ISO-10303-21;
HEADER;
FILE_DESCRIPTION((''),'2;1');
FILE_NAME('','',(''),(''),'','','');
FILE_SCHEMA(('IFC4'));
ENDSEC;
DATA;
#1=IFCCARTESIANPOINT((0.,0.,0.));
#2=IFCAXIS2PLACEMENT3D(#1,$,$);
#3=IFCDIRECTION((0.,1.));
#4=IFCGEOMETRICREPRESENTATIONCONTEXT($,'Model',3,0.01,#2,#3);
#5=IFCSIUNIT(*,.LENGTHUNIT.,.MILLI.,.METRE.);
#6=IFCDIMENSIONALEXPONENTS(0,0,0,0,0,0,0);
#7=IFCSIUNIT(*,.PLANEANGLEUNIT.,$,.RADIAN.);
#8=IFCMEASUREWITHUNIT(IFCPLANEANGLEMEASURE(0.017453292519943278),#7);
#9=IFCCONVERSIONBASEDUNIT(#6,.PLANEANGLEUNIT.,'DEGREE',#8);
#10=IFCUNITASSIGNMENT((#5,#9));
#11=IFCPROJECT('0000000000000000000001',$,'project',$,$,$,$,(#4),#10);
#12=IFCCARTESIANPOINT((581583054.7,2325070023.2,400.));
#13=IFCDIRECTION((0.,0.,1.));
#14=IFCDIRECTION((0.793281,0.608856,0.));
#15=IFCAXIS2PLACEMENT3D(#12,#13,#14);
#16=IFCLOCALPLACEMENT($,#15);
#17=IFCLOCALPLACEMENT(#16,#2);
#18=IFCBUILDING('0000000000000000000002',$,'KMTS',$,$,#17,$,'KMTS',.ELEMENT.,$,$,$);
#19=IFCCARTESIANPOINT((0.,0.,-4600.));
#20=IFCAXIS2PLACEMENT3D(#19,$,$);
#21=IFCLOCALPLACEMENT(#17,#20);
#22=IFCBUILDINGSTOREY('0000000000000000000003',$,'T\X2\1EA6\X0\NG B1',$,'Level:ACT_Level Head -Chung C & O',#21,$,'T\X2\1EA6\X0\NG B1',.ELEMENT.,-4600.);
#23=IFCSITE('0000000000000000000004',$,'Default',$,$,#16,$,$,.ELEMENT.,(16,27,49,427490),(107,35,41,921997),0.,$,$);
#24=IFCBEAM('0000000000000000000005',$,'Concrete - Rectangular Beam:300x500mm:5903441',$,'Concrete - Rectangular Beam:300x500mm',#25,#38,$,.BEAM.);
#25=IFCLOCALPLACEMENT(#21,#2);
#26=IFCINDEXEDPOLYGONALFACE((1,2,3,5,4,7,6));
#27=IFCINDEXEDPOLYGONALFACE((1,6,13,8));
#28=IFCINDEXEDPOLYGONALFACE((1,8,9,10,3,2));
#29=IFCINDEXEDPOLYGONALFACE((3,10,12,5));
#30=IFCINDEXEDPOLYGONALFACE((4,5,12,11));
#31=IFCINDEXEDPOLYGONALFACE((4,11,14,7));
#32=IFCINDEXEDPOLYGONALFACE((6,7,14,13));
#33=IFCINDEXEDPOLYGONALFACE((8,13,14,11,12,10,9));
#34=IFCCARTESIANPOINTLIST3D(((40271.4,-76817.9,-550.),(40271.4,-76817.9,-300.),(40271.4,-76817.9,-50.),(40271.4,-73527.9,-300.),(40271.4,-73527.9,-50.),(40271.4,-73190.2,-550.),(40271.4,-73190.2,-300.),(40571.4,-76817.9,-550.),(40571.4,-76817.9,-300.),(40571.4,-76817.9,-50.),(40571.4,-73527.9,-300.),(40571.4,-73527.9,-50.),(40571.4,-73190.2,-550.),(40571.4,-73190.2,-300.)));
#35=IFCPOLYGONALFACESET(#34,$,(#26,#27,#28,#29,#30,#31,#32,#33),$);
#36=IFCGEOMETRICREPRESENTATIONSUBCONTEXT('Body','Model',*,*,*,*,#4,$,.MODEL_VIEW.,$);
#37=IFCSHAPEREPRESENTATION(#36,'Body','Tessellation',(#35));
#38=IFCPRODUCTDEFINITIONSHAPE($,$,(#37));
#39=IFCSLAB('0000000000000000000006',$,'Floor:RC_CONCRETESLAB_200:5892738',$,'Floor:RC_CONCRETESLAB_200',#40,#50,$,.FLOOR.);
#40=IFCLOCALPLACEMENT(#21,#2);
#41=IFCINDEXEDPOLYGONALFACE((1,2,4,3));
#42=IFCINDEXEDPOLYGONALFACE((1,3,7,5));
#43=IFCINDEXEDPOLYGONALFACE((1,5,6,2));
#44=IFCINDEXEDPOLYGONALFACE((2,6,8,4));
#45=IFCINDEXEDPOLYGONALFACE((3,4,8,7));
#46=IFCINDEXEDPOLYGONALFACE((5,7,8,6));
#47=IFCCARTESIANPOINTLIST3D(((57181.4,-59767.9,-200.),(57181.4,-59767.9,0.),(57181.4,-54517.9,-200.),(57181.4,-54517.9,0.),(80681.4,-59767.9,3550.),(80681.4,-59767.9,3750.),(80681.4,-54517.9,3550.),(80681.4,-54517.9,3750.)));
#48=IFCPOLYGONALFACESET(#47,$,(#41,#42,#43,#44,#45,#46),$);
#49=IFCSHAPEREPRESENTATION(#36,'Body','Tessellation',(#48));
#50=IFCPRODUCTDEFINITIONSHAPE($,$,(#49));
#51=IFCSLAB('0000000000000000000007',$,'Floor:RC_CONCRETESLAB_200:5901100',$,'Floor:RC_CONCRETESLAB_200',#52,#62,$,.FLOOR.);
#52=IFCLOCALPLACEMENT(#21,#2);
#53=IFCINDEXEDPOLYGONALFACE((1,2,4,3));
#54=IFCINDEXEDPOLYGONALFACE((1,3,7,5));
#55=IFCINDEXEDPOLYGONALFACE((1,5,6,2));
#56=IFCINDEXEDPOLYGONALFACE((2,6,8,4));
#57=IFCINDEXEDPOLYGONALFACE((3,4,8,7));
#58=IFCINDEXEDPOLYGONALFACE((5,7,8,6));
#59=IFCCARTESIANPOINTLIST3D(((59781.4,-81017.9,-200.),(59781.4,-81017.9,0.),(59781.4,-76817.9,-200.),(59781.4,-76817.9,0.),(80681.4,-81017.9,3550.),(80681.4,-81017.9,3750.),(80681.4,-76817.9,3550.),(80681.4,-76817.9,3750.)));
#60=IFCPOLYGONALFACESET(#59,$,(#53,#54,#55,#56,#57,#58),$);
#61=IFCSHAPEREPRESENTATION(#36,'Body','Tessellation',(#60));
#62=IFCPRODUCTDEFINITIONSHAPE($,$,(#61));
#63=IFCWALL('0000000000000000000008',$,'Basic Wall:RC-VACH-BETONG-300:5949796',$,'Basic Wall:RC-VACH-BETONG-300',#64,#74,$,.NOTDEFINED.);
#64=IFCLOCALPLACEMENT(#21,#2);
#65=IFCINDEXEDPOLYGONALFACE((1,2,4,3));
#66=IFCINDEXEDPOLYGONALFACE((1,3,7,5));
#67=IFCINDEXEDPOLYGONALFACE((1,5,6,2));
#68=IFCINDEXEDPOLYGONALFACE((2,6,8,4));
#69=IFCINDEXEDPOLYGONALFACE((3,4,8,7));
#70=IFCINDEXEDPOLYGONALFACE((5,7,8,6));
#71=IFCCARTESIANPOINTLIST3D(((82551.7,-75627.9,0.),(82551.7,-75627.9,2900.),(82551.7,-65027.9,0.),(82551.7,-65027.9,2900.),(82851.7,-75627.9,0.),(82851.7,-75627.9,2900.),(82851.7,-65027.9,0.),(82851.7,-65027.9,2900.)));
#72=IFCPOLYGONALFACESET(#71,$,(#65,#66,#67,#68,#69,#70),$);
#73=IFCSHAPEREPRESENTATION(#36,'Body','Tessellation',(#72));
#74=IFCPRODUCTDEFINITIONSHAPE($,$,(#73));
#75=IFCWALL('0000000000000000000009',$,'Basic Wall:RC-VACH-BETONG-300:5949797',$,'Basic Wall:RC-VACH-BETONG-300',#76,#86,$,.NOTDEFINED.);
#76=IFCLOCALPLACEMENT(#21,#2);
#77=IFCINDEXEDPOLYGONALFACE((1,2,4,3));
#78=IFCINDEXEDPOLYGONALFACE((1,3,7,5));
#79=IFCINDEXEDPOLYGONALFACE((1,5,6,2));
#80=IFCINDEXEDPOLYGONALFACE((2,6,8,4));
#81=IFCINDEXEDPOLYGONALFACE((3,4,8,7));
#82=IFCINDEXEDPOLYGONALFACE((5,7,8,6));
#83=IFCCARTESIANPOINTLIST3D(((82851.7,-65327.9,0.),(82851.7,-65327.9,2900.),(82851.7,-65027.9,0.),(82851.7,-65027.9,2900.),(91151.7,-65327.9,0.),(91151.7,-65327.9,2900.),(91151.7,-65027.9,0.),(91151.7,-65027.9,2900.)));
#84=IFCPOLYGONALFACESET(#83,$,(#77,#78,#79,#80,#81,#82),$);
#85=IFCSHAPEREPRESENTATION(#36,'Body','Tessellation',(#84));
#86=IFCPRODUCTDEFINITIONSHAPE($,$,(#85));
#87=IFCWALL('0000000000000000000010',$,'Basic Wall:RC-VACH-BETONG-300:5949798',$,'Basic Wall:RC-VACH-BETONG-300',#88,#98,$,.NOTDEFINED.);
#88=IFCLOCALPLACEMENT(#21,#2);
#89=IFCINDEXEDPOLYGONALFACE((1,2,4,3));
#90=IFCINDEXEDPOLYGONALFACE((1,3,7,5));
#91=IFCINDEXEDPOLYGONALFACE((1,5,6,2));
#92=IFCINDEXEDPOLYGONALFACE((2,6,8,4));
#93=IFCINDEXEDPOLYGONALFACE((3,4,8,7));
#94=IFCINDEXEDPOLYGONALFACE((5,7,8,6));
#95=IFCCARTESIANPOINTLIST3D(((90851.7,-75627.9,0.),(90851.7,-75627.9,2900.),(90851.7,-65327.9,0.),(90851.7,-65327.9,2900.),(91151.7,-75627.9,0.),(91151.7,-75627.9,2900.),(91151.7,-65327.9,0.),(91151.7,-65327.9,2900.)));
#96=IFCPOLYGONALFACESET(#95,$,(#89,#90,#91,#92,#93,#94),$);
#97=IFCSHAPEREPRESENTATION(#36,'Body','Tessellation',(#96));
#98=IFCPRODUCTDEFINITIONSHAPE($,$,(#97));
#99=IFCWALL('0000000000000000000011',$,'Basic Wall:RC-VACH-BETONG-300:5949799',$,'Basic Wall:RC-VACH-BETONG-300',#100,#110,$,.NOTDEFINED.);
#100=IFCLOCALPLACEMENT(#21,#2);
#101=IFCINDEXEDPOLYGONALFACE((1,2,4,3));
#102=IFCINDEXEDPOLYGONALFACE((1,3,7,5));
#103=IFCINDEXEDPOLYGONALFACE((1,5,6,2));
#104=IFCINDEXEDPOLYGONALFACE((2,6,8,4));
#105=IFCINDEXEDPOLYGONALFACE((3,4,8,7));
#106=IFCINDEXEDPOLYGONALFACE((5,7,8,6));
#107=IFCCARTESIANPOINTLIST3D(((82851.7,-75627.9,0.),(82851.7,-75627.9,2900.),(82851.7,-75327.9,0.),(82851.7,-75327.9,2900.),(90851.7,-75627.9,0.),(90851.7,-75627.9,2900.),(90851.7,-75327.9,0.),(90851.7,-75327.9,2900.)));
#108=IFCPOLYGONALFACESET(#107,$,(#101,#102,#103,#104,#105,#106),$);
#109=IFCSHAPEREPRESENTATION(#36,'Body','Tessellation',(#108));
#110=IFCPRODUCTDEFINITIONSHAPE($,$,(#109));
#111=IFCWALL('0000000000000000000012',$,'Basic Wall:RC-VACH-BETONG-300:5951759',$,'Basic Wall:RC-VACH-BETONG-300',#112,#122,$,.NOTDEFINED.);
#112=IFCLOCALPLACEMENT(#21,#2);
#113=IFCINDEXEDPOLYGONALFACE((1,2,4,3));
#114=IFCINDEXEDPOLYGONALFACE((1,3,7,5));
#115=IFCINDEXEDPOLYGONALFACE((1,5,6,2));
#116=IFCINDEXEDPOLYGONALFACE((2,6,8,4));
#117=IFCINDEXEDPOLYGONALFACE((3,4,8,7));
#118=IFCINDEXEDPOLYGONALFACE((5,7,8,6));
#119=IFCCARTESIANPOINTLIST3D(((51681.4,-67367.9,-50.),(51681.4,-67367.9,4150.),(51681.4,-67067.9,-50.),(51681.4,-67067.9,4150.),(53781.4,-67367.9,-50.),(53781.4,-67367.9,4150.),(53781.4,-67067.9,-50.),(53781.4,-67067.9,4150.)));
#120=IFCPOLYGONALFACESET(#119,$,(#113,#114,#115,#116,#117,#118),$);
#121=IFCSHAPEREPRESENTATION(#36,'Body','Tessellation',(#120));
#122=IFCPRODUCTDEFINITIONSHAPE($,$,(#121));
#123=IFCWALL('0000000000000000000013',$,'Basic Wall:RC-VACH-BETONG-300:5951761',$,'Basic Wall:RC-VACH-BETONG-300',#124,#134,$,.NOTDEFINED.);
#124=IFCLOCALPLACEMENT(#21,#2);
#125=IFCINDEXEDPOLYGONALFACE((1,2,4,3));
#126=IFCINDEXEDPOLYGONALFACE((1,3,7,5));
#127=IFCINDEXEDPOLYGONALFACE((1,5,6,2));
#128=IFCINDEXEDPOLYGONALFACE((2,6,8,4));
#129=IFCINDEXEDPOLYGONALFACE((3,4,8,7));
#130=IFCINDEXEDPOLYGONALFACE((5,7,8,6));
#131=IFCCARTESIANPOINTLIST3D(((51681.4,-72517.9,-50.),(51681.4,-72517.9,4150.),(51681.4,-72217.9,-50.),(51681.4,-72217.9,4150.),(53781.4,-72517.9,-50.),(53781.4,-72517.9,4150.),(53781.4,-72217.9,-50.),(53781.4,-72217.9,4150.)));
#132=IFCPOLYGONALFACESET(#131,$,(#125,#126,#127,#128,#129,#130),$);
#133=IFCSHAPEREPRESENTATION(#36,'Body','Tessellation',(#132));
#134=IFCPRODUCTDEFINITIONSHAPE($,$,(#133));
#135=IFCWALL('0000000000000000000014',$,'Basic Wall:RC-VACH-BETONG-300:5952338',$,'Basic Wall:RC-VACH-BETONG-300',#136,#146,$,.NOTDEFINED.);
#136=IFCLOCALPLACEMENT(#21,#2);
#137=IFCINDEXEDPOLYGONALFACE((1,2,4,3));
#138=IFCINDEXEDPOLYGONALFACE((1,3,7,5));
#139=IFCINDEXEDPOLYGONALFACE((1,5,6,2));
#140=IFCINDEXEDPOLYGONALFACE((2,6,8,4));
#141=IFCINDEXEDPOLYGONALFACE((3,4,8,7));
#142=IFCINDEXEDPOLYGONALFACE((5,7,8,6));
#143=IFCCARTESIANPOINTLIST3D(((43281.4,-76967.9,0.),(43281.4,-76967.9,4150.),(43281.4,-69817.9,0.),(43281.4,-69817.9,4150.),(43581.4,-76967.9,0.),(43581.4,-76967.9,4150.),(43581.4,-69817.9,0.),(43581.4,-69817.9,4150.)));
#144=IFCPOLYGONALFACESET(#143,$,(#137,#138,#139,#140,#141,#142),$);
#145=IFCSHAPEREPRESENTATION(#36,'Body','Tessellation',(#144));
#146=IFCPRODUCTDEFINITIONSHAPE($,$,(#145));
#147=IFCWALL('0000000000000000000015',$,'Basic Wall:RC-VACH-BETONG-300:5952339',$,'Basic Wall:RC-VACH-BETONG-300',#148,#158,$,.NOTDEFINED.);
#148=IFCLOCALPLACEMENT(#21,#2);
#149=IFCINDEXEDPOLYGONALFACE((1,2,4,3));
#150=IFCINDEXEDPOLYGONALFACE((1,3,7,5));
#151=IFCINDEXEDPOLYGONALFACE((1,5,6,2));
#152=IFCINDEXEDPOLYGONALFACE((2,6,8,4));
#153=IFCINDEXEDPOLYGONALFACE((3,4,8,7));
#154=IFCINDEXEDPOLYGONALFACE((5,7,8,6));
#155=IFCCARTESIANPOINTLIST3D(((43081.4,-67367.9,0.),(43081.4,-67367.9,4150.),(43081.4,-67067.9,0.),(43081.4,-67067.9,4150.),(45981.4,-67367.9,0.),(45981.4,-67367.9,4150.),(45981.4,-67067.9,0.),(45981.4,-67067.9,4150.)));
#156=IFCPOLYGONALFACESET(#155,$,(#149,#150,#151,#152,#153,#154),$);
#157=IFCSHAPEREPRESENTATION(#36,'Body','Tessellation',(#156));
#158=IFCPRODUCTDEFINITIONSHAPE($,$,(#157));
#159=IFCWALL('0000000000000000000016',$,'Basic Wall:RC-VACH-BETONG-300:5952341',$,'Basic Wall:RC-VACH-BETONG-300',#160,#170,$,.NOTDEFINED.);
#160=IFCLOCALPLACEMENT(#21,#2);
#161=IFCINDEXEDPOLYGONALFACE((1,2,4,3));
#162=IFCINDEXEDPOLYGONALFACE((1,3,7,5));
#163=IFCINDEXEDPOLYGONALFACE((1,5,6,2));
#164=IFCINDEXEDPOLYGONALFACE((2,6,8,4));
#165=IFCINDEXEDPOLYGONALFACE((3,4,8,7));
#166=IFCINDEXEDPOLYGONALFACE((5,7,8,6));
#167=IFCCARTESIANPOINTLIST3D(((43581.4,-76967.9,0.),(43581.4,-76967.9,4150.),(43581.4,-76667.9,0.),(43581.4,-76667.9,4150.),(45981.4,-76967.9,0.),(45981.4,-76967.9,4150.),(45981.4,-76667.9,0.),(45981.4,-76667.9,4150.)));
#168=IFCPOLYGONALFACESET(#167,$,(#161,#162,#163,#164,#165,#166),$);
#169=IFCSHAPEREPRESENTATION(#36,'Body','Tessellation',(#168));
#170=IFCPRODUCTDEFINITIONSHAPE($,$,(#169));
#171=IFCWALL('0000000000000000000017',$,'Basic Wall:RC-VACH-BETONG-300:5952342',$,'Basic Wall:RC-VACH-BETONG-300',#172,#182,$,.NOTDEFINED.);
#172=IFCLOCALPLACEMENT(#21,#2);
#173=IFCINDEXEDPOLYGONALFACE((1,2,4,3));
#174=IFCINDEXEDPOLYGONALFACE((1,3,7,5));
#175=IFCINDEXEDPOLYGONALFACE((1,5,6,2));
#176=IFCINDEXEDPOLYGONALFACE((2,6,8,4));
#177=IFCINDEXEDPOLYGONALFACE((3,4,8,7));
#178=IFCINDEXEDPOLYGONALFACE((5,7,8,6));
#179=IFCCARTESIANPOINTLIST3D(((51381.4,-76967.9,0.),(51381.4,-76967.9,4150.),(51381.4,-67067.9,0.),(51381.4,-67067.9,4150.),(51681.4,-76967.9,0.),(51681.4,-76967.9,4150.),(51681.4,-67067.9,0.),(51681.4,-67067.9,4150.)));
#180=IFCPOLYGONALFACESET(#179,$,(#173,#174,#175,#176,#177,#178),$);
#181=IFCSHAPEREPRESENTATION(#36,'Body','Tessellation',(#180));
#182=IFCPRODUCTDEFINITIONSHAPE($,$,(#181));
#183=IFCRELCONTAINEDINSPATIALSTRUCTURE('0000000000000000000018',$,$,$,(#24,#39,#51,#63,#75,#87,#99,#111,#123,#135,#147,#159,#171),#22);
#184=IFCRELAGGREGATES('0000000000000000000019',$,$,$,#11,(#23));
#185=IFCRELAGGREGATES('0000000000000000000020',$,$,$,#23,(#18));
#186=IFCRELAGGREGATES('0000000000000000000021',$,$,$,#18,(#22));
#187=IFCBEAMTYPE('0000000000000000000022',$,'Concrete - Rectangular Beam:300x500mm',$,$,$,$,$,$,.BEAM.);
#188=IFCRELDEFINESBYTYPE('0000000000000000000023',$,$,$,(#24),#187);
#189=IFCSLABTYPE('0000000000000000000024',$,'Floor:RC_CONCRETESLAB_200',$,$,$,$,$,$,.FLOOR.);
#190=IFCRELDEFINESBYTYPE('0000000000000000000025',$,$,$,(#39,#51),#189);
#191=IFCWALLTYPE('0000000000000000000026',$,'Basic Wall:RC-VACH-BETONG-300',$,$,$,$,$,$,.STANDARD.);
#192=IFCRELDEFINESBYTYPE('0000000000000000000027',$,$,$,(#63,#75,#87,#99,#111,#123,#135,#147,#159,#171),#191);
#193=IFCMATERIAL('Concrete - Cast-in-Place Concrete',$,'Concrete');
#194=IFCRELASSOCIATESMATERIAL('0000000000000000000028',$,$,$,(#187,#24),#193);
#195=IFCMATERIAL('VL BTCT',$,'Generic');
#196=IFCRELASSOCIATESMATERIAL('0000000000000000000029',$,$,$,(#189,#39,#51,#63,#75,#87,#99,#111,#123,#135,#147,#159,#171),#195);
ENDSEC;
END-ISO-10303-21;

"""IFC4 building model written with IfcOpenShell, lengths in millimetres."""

from ifc_helpers import new_model, entity, si_unit, converted_unit, direction, frame, frame_2d, origin, place, context, subcontext, project, spatial, indexed_curve, rectangle, outline, extrude, source, transform, mapped, material, type_object, type_shapes, element, save


model = new_model("IFC4")

# Units and contexts
model_context = context("Model", 3, precision=0.01, world=origin(), true_north=direction((0.0, 1.0)))
body_context = subcontext(model_context, "Body", "Model", "MODEL_VIEW")
ifc_project = project(units=[si_unit("LENGTHUNIT", "METRE", prefix="MILLI"), converted_unit("PLANEANGLEUNIT", "DEGREE", entity("IfcPlaneAngleMeasure", 0.017453292519943278), si_unit("PLANEANGLEUNIT", "RADIAN"), dimensions=[0, 0, 0, 0, 0, 0, 0])], contexts=[model_context])

# Site, building, storey
site_placement = place(None, frame((581583054.7, 2325070023.2, 400.0), z_axis=(0.0, 0.0, 1.0), x_axis=(0.793281, 0.608856, 0.0)))
site = spatial("IfcSite", under=ifc_project, at=site_placement, Name="Default", CompositionType="ELEMENT", RefLatitude=(16, 27, 49, 427490), RefLongitude=(107, 35, 41, 921997), RefElevation=0.0)
building_placement = place(site_placement, origin())
building = spatial("IfcBuilding", under=site, at=building_placement, Name="KMTS", LongName="KMTS", CompositionType="ELEMENT")
storey_placement = place(building_placement, frame((0.0, 0.0, -4600.0)))
storey = spatial("IfcBuildingStorey", under=building, at=storey_placement, Name="TẦNG B1", ObjectType="Level:ACT_Level Head -Chung C & O", LongName="TẦNG B1", CompositionType="ELEMENT", Elevation=-4600.0)

# Beam
ifc_material_1 = material(Name="VL BTCT", Category="Generic")
ifc_material_2 = material(Name="Concrete - Cast-in-Place Concrete", Category="Concrete")
beam_type_1 = type_object("IfcBeamType", Name="Concrete - Rectangular Beam:300x500mm", PredefinedType="BEAM", material=ifc_material_2)
shared_shape_1 = source(origin(), body_context, "Body", "SweptSolid", [
    extrude(outline(indexed_curve([(-250.0, -1651.2), (0.0, -1651.2), (0.0, -1313.5), (250.0, -1313.5), (250.0, 1976.5), (0.0, 1976.5), (-250.0, 1976.5), (-250.0, -1651.2)], self_intersect=False)), frame((0.0, 1976.5, 250.0), z_axis=(1.0, 0.0, 0.0), x_axis=(0.0, 0.0, 1.0)), (0.0, 0.0, 1.0), 300.0),
])
type_shapes(beam_type_1, [shared_shape_1])
beam_1_placement = place(storey_placement, frame((40271.4, -76817.9, -550.0)))
element("IfcBeam", 1, at=beam_1_placement, inside=storey, type_object=beam_type_1, material=ifc_material_2, Name="Concrete - Rectangular Beam:300x500mm:5903441", ObjectType="Concrete - Rectangular Beam:300x500mm", PredefinedType="BEAM", context=body_context, shape_type="MappedRepresentation", body=[
    mapped(shared_shape_1, transform((0.0, 0.0, 0.0), scale=1.0)),
])

# Slabs
slab_type = type_object("IfcSlabType", Name="Floor:RC_CONCRETESLAB_200", PredefinedType="FLOOR", material=ifc_material_1)
slab_1_placement = place(storey_placement, frame((57181.4, -59767.9, -200.0)))
element("IfcSlab", 2, at=slab_1_placement, inside=storey, type_object=slab_type, material=ifc_material_1, Name="Floor:RC_CONCRETESLAB_200:5892738", ObjectType="Floor:RC_CONCRETESLAB_200", PredefinedType="FLOOR", context=body_context, shape_type="SweptSolid", body=[
    extrude(rectangle(XDim=5250.0, YDim=23797.3, at=frame_2d((0.0, 0.0), x_axis=(0.0, 1.0))), frame((11750.0, 2625.0, 2075.0), z_axis=(-0.157581, 0.0, 0.987506), x_axis=(0.987506, 0.0, 0.157581)), (-0.157581, 0.0, -0.987506), 200.0),
])
slab_2_placement = place(storey_placement, frame((59781.4, -81017.9, -200.0)))
element("IfcSlab", 3, at=slab_2_placement, inside=storey, type_object=slab_type, material=ifc_material_1, Name="Floor:RC_CONCRETESLAB_200:5901100", ObjectType="Floor:RC_CONCRETESLAB_200", PredefinedType="FLOOR", context=body_context, shape_type="SweptSolid", body=[
    extrude(rectangle(XDim=21233.8, YDim=4200.0, at=frame_2d((0.0, 0.0), x_axis=(-1.0, 0.0))), frame((10450.0, 2100.0, 2075.0), z_axis=(-0.176606, 0.0, 0.984282), x_axis=(0.984282, 0.0, 0.176606)), (-0.176606, 0.0, -0.984282), 200.0),
])

# Walls
wall_type_1 = type_object("IfcWallType", Name="Basic Wall:RC-VACH-BETONG-300", PredefinedType="STANDARD")
wall_1_placement = place(storey_placement, frame((82701.7, -75627.9, 0.0), z_axis=(0.0, 0.0, 1.0), x_axis=(0.0, 1.0, 0.0)))
element("IfcWall", 4, at=wall_1_placement, inside=storey, type_object=wall_type_1, material=ifc_material_1, Name="Basic Wall:RC-VACH-BETONG-300:5949796", ObjectType="Basic Wall:RC-VACH-BETONG-300", PredefinedType="NOTDEFINED", context=body_context, shape_type="SweptSolid", body=[
    extrude(outline(indexed_curve([(10600.0, 150.0), (0.0, 150.0), (0.0, -150.0), (10600.0, -150.0), (10600.0, 150.0)], self_intersect=False)), origin(), (0.0, 0.0, 1.0), 2900.0),
])
wall_2_placement = place(storey_placement, frame((82851.7, -65177.9, 0.0)))
element("IfcWall", 5, at=wall_2_placement, inside=storey, type_object=wall_type_1, material=ifc_material_1, Name="Basic Wall:RC-VACH-BETONG-300:5949797", ObjectType="Basic Wall:RC-VACH-BETONG-300", PredefinedType="NOTDEFINED", context=body_context, shape_type="SweptSolid", body=[
    extrude(outline(indexed_curve([(8300.0, 150.0), (0.0, 150.0), (0.0, -150.0), (8300.0, -150.0), (8300.0, 150.0)], self_intersect=False)), origin(), (0.0, 0.0, 1.0), 2900.0),
])
wall_3_placement = place(storey_placement, frame((91001.7, -65327.9, 0.0), z_axis=(0.0, 0.0, 1.0), x_axis=(0.0, -1.0, 0.0)))
element("IfcWall", 6, at=wall_3_placement, inside=storey, type_object=wall_type_1, material=ifc_material_1, Name="Basic Wall:RC-VACH-BETONG-300:5949798", ObjectType="Basic Wall:RC-VACH-BETONG-300", PredefinedType="NOTDEFINED", context=body_context, shape_type="SweptSolid", body=[
    extrude(outline(indexed_curve([(10300.0, 150.0), (0.0, 150.0), (0.0, -150.0), (10300.0, -150.0), (10300.0, 150.0)], self_intersect=False)), origin(), (0.0, 0.0, 1.0), 2900.0),
])
wall_4_placement = place(storey_placement, frame((82851.7, -75477.9, 0.0)))
element("IfcWall", 7, at=wall_4_placement, inside=storey, type_object=wall_type_1, material=ifc_material_1, Name="Basic Wall:RC-VACH-BETONG-300:5949799", ObjectType="Basic Wall:RC-VACH-BETONG-300", PredefinedType="NOTDEFINED", context=body_context, shape_type="SweptSolid", body=[
    extrude(outline(indexed_curve([(8000.0, 150.0), (0.0, 150.0), (0.0, -150.0), (8000.0, -150.0), (8000.0, 150.0)], self_intersect=False)), origin(), (0.0, 0.0, 1.0), 2900.0),
])
wall_5_placement = place(storey_placement, frame((53781.4, -67217.9, -50.0), z_axis=(0.0, 0.0, 1.0), x_axis=(-1.0, 0.0, 0.0)))
element("IfcWall", 8, at=wall_5_placement, inside=storey, type_object=wall_type_1, material=ifc_material_1, Name="Basic Wall:RC-VACH-BETONG-300:5951759", ObjectType="Basic Wall:RC-VACH-BETONG-300", PredefinedType="NOTDEFINED", context=body_context, shape_type="SweptSolid", body=[
    extrude(outline(indexed_curve([(2100.0, 150.0), (0.0, 150.0), (0.0, -150.0), (2100.0, -150.0), (2100.0, 150.0)], self_intersect=False)), origin(), (0.0, 0.0, 1.0), 4200.0),
])
wall_6_placement = place(storey_placement, frame((53781.4, -72367.9, -50.0), z_axis=(0.0, 0.0, 1.0), x_axis=(-1.0, 0.0, 0.0)))
element("IfcWall", 9, at=wall_6_placement, inside=storey, type_object=wall_type_1, material=ifc_material_1, Name="Basic Wall:RC-VACH-BETONG-300:5951761", ObjectType="Basic Wall:RC-VACH-BETONG-300", PredefinedType="NOTDEFINED", context=body_context, shape_type="SweptSolid", body=[
    extrude(outline(indexed_curve([(2100.0, 150.0), (0.0, 150.0), (0.0, -150.0), (2100.0, -150.0), (2100.0, 150.0)], self_intersect=False)), origin(), (0.0, 0.0, 1.0), 4200.0),
])
wall_7_placement = place(storey_placement, frame((43431.4, -69817.9, 0.0), z_axis=(0.0, 0.0, 1.0), x_axis=(0.0, -1.0, 0.0)))
element("IfcWall", 10, at=wall_7_placement, inside=storey, type_object=wall_type_1, material=ifc_material_1, Name="Basic Wall:RC-VACH-BETONG-300:5952338", ObjectType="Basic Wall:RC-VACH-BETONG-300", PredefinedType="NOTDEFINED", context=body_context, shape_type="SweptSolid", body=[
    extrude(outline(indexed_curve([(7150.0, 150.0), (0.0, 150.0), (0.0, -150.0), (7150.0, -150.0), (7150.0, 150.0)], self_intersect=False)), origin(), (0.0, 0.0, 1.0), 4150.0),
])
wall_8_placement = place(storey_placement, frame((45981.4, -67217.9, 0.0), z_axis=(0.0, 0.0, 1.0), x_axis=(-1.0, 0.0, 0.0)))
element("IfcWall", 11, at=wall_8_placement, inside=storey, type_object=wall_type_1, material=ifc_material_1, Name="Basic Wall:RC-VACH-BETONG-300:5952339", ObjectType="Basic Wall:RC-VACH-BETONG-300", PredefinedType="NOTDEFINED", context=body_context, shape_type="SweptSolid", body=[
    extrude(outline(indexed_curve([(2900.0, 150.0), (0.0, 150.0), (0.0, -150.0), (2900.0, -150.0), (2900.0, 150.0)], self_intersect=False)), origin(), (0.0, 0.0, 1.0), 4150.0),
])
wall_9_placement = place(storey_placement, frame((45981.4, -76817.9, 0.0), z_axis=(0.0, 0.0, 1.0), x_axis=(-1.0, 0.0, 0.0)))
element("IfcWall", 12, at=wall_9_placement, inside=storey, type_object=wall_type_1, material=ifc_material_1, Name="Basic Wall:RC-VACH-BETONG-300:5952341", ObjectType="Basic Wall:RC-VACH-BETONG-300", PredefinedType="NOTDEFINED", context=body_context, shape_type="SweptSolid", body=[
    extrude(outline(indexed_curve([(2400.0, 150.0), (0.0, 150.0), (0.0, -150.0), (2400.0, -150.0), (2400.0, 150.0)], self_intersect=False)), origin(), (0.0, 0.0, 1.0), 4150.0),
])
wall_10_placement = place(storey_placement, frame((51531.4, -67067.9, 0.0), z_axis=(0.0, 0.0, 1.0), x_axis=(0.0, -1.0, 0.0)))
element("IfcWall", 13, at=wall_10_placement, inside=storey, type_object=wall_type_1, material=ifc_material_1, Name="Basic Wall:RC-VACH-BETONG-300:5952342", ObjectType="Basic Wall:RC-VACH-BETONG-300", PredefinedType="NOTDEFINED", context=body_context, shape_type="SweptSolid", body=[
    extrude(outline(indexed_curve([(9900.0, 150.0), (0.0, 150.0), (0.0, -150.0), (9900.0, -150.0), (9900.0, 150.0)], self_intersect=False)), origin(), (0.0, 0.0, 1.0), 4150.0),
])

save(model, "model.ifc")
